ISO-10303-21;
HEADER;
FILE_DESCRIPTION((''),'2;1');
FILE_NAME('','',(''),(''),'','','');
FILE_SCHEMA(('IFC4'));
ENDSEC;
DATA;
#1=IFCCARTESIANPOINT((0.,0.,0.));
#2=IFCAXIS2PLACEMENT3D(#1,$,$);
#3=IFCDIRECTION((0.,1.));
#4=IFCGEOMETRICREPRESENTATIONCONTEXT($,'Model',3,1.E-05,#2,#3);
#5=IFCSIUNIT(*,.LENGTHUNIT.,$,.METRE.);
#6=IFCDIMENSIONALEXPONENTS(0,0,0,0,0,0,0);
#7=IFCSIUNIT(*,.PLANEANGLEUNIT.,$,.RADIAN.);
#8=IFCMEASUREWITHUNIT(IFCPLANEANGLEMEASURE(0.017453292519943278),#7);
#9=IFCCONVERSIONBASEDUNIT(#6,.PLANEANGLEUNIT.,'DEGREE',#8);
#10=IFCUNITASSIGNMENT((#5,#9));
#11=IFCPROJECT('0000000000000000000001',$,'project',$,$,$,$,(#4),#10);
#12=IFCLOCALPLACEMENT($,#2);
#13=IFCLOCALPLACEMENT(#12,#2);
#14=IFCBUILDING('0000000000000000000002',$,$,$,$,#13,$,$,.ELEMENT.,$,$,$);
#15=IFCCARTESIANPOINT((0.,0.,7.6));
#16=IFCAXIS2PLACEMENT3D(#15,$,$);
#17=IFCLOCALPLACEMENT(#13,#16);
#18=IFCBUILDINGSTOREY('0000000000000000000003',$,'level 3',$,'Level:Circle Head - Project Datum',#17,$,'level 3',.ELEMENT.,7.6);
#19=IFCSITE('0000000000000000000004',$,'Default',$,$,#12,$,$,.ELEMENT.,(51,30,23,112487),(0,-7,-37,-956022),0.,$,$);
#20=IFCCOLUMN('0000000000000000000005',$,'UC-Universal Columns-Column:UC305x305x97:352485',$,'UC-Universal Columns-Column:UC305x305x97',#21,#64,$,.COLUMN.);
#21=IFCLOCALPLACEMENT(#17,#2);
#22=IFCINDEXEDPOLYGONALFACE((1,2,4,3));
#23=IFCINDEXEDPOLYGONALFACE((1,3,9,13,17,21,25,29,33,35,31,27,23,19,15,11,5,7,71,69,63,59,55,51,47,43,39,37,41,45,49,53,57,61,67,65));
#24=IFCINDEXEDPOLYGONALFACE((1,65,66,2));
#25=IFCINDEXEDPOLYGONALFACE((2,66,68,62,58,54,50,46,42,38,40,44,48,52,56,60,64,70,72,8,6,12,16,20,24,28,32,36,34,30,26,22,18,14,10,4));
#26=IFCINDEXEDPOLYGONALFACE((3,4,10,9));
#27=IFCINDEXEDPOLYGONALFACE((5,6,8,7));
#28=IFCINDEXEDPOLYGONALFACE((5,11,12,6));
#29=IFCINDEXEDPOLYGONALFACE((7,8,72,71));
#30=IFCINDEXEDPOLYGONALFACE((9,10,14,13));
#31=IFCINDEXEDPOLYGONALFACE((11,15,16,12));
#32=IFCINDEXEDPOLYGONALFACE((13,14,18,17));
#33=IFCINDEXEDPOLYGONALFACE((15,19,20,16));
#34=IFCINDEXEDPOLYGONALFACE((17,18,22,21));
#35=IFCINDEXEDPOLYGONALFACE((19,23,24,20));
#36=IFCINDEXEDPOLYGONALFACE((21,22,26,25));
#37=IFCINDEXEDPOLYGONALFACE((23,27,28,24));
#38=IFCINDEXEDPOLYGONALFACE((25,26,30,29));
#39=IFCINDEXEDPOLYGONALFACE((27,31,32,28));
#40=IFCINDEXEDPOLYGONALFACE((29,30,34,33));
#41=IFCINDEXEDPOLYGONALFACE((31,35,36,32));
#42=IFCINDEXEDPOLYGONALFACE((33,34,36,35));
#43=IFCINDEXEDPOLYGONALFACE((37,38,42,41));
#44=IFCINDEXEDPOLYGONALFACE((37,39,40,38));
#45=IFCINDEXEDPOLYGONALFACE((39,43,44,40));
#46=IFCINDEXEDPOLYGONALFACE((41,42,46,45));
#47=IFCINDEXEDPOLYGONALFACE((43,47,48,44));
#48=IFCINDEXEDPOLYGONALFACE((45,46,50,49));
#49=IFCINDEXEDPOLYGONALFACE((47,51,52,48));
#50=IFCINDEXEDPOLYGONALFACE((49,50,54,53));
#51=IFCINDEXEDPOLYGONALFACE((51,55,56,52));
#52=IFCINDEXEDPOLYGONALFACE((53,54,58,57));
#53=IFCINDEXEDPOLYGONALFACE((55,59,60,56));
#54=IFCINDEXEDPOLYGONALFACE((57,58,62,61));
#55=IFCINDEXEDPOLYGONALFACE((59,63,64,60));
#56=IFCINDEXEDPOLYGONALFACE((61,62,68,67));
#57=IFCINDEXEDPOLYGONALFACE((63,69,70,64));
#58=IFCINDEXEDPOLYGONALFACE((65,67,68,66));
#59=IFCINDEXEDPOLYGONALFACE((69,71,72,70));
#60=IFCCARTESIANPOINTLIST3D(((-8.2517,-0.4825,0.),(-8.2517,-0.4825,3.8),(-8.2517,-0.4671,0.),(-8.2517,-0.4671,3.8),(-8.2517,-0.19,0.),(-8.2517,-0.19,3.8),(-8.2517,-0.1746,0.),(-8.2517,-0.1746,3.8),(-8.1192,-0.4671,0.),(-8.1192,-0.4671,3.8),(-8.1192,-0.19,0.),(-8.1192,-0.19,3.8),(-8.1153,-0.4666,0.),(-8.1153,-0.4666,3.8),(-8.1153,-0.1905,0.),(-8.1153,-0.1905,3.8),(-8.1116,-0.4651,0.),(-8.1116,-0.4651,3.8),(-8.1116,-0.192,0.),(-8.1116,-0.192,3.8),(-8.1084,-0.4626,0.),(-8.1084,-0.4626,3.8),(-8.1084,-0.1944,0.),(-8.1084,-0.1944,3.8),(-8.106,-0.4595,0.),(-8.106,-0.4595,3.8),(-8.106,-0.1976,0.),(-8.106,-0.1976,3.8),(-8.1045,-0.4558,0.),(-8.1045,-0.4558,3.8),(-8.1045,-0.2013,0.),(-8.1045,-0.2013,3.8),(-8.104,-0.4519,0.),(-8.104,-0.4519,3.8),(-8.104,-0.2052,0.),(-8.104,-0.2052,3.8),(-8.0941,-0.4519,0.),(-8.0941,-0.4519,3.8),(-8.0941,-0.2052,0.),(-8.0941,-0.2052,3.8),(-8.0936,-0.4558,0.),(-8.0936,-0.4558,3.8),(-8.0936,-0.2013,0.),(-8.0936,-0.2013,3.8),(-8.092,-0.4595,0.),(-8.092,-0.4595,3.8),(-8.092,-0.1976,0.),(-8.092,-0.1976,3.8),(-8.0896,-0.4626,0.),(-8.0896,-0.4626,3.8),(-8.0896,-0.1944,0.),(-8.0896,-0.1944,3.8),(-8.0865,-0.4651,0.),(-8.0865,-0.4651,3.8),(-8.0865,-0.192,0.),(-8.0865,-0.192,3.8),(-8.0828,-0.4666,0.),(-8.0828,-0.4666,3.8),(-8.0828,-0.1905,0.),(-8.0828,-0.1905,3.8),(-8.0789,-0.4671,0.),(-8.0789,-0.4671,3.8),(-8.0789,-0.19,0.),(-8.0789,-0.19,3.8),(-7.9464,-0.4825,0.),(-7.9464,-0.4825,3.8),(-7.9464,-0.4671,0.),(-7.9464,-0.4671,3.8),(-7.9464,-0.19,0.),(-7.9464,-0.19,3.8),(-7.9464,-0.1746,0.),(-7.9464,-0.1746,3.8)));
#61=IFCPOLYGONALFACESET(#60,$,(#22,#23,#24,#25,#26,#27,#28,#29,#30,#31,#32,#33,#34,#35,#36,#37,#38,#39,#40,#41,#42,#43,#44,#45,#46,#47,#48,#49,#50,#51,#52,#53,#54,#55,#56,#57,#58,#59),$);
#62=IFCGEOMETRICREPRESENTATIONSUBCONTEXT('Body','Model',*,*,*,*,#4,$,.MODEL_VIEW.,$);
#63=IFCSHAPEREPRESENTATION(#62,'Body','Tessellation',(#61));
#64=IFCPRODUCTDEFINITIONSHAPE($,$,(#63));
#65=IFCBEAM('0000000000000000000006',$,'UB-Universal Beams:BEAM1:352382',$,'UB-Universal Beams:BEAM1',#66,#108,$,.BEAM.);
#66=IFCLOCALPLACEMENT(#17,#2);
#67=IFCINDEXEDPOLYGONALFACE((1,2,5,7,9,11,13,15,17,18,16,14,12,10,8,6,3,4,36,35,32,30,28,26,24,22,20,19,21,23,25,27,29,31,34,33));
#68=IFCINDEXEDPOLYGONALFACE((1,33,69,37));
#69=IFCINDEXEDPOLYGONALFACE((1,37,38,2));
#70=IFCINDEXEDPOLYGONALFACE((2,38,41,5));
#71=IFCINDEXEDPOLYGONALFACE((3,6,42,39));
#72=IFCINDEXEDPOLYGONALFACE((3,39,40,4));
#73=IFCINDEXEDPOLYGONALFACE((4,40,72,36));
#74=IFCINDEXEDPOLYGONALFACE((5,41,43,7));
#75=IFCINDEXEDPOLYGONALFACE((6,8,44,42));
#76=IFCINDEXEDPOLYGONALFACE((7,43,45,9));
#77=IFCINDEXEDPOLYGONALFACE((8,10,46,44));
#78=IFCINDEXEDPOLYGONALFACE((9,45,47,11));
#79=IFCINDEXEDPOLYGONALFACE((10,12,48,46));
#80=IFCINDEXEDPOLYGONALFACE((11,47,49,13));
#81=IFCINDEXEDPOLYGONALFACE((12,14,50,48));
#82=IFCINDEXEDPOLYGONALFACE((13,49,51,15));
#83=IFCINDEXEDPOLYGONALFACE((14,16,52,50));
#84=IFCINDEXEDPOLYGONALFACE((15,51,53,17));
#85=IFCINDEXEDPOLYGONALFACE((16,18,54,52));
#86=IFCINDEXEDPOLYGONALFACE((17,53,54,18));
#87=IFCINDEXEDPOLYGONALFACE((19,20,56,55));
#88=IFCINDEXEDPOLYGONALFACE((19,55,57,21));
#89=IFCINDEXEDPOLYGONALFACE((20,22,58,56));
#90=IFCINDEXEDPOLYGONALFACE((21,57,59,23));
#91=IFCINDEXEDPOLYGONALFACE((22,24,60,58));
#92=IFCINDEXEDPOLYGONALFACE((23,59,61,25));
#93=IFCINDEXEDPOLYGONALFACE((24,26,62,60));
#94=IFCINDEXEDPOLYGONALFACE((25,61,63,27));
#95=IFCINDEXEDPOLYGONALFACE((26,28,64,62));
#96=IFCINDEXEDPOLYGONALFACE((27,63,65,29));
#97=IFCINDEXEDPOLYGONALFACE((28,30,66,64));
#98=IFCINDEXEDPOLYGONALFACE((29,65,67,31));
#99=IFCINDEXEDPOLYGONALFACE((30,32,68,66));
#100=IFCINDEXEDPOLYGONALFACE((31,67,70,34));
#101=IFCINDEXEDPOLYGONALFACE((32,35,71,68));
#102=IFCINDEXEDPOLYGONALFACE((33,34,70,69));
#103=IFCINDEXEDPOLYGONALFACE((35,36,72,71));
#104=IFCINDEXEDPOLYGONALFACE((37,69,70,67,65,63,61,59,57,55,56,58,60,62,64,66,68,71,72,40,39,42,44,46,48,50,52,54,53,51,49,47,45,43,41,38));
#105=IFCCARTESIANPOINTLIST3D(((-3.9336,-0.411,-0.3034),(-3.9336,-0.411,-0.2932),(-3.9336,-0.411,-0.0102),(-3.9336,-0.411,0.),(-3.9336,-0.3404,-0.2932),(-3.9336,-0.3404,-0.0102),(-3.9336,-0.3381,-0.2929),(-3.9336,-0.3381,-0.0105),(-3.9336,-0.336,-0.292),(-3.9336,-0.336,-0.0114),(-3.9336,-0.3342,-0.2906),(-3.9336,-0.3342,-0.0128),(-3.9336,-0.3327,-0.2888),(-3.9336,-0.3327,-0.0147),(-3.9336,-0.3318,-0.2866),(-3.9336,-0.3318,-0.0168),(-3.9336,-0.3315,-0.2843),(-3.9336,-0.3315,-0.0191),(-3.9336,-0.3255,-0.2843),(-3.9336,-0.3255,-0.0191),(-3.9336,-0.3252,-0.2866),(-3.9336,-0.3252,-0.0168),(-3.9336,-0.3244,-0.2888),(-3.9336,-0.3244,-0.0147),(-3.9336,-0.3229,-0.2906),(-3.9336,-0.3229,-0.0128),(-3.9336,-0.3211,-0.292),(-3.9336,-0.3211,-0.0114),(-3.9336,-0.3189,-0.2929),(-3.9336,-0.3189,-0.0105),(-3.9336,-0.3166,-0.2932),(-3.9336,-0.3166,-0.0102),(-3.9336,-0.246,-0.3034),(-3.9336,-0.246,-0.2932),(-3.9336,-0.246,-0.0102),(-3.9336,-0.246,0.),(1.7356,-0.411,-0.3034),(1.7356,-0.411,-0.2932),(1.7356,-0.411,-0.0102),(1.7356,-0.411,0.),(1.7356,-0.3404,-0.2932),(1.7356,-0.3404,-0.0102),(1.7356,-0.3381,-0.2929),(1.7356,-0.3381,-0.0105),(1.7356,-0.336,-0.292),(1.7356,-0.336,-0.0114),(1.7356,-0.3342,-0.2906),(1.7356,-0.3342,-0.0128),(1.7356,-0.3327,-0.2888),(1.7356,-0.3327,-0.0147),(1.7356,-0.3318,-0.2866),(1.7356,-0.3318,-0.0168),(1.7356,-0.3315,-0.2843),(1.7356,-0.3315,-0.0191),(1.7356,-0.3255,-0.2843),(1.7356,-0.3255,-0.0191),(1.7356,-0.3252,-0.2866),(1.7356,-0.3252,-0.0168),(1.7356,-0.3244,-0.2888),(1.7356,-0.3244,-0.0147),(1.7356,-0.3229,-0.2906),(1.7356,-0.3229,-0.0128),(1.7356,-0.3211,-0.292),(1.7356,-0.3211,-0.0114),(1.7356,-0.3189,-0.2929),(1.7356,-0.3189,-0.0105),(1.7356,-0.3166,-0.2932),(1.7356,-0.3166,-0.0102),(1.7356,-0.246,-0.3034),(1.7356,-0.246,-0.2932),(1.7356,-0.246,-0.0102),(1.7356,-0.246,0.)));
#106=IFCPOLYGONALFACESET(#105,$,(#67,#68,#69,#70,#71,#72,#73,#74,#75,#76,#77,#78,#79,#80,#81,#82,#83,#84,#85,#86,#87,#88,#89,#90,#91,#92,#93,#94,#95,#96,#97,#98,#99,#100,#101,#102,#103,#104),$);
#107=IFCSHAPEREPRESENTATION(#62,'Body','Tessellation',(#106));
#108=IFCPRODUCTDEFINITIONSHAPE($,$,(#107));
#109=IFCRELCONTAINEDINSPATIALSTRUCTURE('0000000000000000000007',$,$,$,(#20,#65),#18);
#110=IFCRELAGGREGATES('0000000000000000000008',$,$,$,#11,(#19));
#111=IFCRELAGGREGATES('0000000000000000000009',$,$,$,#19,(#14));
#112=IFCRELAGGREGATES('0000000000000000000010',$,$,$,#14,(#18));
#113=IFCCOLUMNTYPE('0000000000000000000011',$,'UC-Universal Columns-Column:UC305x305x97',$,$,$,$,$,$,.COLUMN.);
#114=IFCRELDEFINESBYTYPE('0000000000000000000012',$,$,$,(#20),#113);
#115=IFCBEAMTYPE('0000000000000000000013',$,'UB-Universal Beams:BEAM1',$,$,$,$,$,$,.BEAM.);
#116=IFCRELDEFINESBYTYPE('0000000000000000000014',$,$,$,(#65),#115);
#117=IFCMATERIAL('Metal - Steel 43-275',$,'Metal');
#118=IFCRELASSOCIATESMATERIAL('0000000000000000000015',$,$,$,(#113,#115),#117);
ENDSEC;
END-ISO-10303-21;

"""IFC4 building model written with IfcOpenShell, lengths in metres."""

from ifc_helpers import new_model, entity, si_unit, converted_unit, direction, frame, frame_2d, origin, origin_2d_with_axis, place, context, subcontext, project, spatial, polyline, circle_curve, parameter, trimmed, segment, composite_curve, i_section, outline, extrude, source, transform, mapped, material, material_profile, profile_set, type_object, type_shapes, element, save


model = new_model("IFC4")

# Units and contexts
model_context = context("Model", 3, precision=1e-05, world=origin(), true_north=direction((0.0, 1.0)))
body_context = subcontext(model_context, "Body", "Model", "MODEL_VIEW")
ifc_project = project(units=[si_unit("LENGTHUNIT", "METRE"), converted_unit("PLANEANGLEUNIT", "DEGREE", entity("IfcPlaneAngleMeasure", 0.017453292519943278), si_unit("PLANEANGLEUNIT", "RADIAN"), dimensions=[0, 0, 0, 0, 0, 0, 0])], contexts=[model_context])

# Site, building, storey
site_placement = place(None, origin())
site = spatial("IfcSite", under=ifc_project, at=site_placement, Name="Default", CompositionType="ELEMENT", RefLatitude=(51, 30, 23, 112487), RefLongitude=(0, -7, -37, -956022), RefElevation=0.0)
building_placement = place(site_placement, origin())
building = spatial("IfcBuilding", under=site, at=building_placement, CompositionType="ELEMENT")
storey_placement = place(building_placement, frame((0.0, 0.0, 7.6)))
storey = spatial("IfcBuildingStorey", under=building, at=storey_placement, Name="level 3", ObjectType="Level:Circle Head - Project Datum", LongName="level 3", CompositionType="ELEMENT", Elevation=7.6)

# Column
ifc_material_1 = material(Name="Metal - Steel 43-275", Category="Metal")
ifc_material_profile_1 = material_profile(ifc_material_1, i_section(OverallWidth=0.3053, OverallDepth=0.3079, WebThickness=0.0099, FlangeThickness=0.0154, FilletRadius=0.0152, at=frame_2d((0.0, 0.0), x_axis=(1.0, 0.0))), Name="UC305x305x97")
ifc_profile_set_1 = profile_set([ifc_material_profile_1], Name="UC305x305x97")
column_type = type_object("IfcColumnType", Name="UC-Universal Columns-Column:UC305x305x97", PredefinedType="COLUMN", material=ifc_profile_set_1)
shared_shape_1 = source(origin(), body_context, "Body", "SweptSolid", [
    extrude(i_section(OverallWidth=0.3053, OverallDepth=0.3079, WebThickness=0.0099, FlangeThickness=0.0154, FilletRadius=0.0152, at=origin_2d_with_axis()), frame((0.0, 0.0, 7.6), z_axis=(0.0, 0.0, 1.0), x_axis=(-1.0, 0.0, 0.0)), (0.0, 0.0, 1.0), 3.8),
])
type_shapes(column_type, [shared_shape_1])
column_placement = place(storey_placement, frame((-8.099, -0.3285, -7.6)))
element("IfcColumn", 1, at=column_placement, inside=storey, type_object=column_type, Name="UC-Universal Columns-Column:UC305x305x97:352485", ObjectType="UC-Universal Columns-Column:UC305x305x97", PredefinedType="COLUMN", context=body_context, shape_type="MappedRepresentation", body=[
    mapped(shared_shape_1, transform((0.0, 0.0, 0.0), scale=1.0)),
])

# Beam
ifc_material_profile_2 = material_profile(ifc_material_1, outline(composite_curve([segment(polyline([(-0.0825, -0.1415), (-0.0825, -0.1517)]), True, "CONTINUOUS"), segment(polyline([(-0.0825, -0.1517), (0.0825, -0.1517)]), True, "CONTINUOUS"), segment(polyline([(0.0825, -0.1517), (0.0825, -0.1415)]), True, "CONTINUOUS"), segment(polyline([(0.0825, -0.1415), (0.0119, -0.1415)]), True, "CONTINUOUS"), segment(trimmed(circle_curve(frame_2d((0.0119, -0.1326), x_axis=(1.0, 0.0)), 0.0089), [parameter(180.0)], [parameter(270.0)], True, "PARAMETER"), False, "CONTINUOUS"), segment(polyline([(0.003, -0.1326), (0.003, 0.1326)]), True, "CONTINUOUS"), segment(trimmed(circle_curve(frame_2d((0.0119, 0.1326), x_axis=(1.0, 0.0)), 0.0089), [parameter(90.0)], [parameter(180.0)], True, "PARAMETER"), False, "CONTINUOUS"), segment(polyline([(0.0119, 0.1415), (0.0825, 0.1415)]), True, "CONTINUOUS"), segment(polyline([(0.0825, 0.1415), (0.0825, 0.1517)]), True, "CONTINUOUS"), segment(polyline([(0.0825, 0.1517), (-0.0825, 0.1517)]), True, "CONTINUOUS"), segment(polyline([(-0.0825, 0.1517), (-0.0825, 0.1415)]), True, "CONTINUOUS"), segment(polyline([(-0.0825, 0.1415), (-0.0119, 0.1415)]), True, "CONTINUOUS"), segment(trimmed(circle_curve(frame_2d((-0.0119, 0.1326), x_axis=(1.0, 0.0)), 0.0089), [parameter(360.0)], [parameter(90.0)], True, "PARAMETER"), False, "CONTINUOUS"), segment(polyline([(-0.003, 0.1326), (-0.003, -0.1326)]), True, "CONTINUOUS"), segment(trimmed(circle_curve(frame_2d((-0.0119, -0.1326), x_axis=(1.0, 0.0)), 0.0089), [parameter(270.0)], [parameter(360.0)], True, "PARAMETER"), False, "CONTINUOUS"), segment(polyline([(-0.0119, -0.1415), (-0.0825, -0.1415)]), True, "CONTINUOUS")], self_intersect=False)), Name="BEAM1")
ifc_profile_set_2 = profile_set([ifc_material_profile_2], Name="BEAM1")
beam_type_1 = type_object("IfcBeamType", Name="UB-Universal Beams:BEAM1", PredefinedType="BEAM", material=ifc_profile_set_2)
shared_shape_2 = source(origin(), body_context, "Body", "SweptSolid", [
    extrude(outline(composite_curve([segment(polyline([(-0.0825, -0.1415), (-0.0825, -0.1517)]), True, "CONTINUOUS"), segment(polyline([(-0.0825, -0.1517), (0.0825, -0.1517)]), True, "CONTINUOUS"), segment(polyline([(0.0825, -0.1517), (0.0825, -0.1415)]), True, "CONTINUOUS"), segment(polyline([(0.0825, -0.1415), (0.0119, -0.1415)]), True, "CONTINUOUS"), segment(trimmed(circle_curve(frame_2d((0.0119, -0.1326), x_axis=(0.0, -1.0)), 0.0089), [parameter(270.0)], [parameter(360.0)], True, "PARAMETER"), False, "CONTINUOUS"), segment(polyline([(0.003, -0.1326), (0.003, 0.1326)]), True, "CONTINUOUS"), segment(trimmed(circle_curve(frame_2d((0.0119, 0.1326), x_axis=(-1.0, 0.0)), 0.0089), [parameter(270.0)], [parameter(360.0)], True, "PARAMETER"), False, "CONTINUOUS"), segment(polyline([(0.0119, 0.1415), (0.0825, 0.1415)]), True, "CONTINUOUS"), segment(polyline([(0.0825, 0.1415), (0.0825, 0.1517)]), True, "CONTINUOUS"), segment(polyline([(0.0825, 0.1517), (-0.0825, 0.1517)]), True, "CONTINUOUS"), segment(polyline([(-0.0825, 0.1517), (-0.0825, 0.1415)]), True, "CONTINUOUS"), segment(polyline([(-0.0825, 0.1415), (-0.0119, 0.1415)]), True, "CONTINUOUS"), segment(trimmed(circle_curve(frame_2d((-0.0119, 0.1326), x_axis=(0.0, 1.0)), 0.0089), [parameter(270.0)], [parameter(360.0)], True, "PARAMETER"), False, "CONTINUOUS"), segment(polyline([(-0.003, 0.1326), (-0.003, -0.1326)]), True, "CONTINUOUS"), segment(trimmed(circle_curve(frame_2d((-0.0119, -0.1326), x_axis=(1.0, 0.0)), 0.0089), [parameter(270.0)], [parameter(0.0)], True, "PARAMETER"), False, "CONTINUOUS"), segment(polyline([(-0.0119, -0.1415), (-0.0825, -0.1415)]), True, "CONTINUOUS")], self_intersect=False)), frame((-2.8346, 0.0, 0.0), z_axis=(-1.0, 0.0, 0.0), x_axis=(0.0, -1.0, 0.0)), (0.0, 0.0, -1.0), 5.6692),
])
type_shapes(beam_type_1, [shared_shape_2])
beam_1_placement = place(storey_placement, frame((-1.099, -0.3285, -0.1517)))
element("IfcBeam", 2, at=beam_1_placement, inside=storey, type_object=beam_type_1, Name="UB-Universal Beams:BEAM1:352382", ObjectType="UB-Universal Beams:BEAM1", PredefinedType="BEAM", context=body_context, shape_type="MappedRepresentation", body=[
    mapped(shared_shape_2, transform((0.0, 0.0, 0.0), scale=1.0)),
])

save(model, "model.ifc")
